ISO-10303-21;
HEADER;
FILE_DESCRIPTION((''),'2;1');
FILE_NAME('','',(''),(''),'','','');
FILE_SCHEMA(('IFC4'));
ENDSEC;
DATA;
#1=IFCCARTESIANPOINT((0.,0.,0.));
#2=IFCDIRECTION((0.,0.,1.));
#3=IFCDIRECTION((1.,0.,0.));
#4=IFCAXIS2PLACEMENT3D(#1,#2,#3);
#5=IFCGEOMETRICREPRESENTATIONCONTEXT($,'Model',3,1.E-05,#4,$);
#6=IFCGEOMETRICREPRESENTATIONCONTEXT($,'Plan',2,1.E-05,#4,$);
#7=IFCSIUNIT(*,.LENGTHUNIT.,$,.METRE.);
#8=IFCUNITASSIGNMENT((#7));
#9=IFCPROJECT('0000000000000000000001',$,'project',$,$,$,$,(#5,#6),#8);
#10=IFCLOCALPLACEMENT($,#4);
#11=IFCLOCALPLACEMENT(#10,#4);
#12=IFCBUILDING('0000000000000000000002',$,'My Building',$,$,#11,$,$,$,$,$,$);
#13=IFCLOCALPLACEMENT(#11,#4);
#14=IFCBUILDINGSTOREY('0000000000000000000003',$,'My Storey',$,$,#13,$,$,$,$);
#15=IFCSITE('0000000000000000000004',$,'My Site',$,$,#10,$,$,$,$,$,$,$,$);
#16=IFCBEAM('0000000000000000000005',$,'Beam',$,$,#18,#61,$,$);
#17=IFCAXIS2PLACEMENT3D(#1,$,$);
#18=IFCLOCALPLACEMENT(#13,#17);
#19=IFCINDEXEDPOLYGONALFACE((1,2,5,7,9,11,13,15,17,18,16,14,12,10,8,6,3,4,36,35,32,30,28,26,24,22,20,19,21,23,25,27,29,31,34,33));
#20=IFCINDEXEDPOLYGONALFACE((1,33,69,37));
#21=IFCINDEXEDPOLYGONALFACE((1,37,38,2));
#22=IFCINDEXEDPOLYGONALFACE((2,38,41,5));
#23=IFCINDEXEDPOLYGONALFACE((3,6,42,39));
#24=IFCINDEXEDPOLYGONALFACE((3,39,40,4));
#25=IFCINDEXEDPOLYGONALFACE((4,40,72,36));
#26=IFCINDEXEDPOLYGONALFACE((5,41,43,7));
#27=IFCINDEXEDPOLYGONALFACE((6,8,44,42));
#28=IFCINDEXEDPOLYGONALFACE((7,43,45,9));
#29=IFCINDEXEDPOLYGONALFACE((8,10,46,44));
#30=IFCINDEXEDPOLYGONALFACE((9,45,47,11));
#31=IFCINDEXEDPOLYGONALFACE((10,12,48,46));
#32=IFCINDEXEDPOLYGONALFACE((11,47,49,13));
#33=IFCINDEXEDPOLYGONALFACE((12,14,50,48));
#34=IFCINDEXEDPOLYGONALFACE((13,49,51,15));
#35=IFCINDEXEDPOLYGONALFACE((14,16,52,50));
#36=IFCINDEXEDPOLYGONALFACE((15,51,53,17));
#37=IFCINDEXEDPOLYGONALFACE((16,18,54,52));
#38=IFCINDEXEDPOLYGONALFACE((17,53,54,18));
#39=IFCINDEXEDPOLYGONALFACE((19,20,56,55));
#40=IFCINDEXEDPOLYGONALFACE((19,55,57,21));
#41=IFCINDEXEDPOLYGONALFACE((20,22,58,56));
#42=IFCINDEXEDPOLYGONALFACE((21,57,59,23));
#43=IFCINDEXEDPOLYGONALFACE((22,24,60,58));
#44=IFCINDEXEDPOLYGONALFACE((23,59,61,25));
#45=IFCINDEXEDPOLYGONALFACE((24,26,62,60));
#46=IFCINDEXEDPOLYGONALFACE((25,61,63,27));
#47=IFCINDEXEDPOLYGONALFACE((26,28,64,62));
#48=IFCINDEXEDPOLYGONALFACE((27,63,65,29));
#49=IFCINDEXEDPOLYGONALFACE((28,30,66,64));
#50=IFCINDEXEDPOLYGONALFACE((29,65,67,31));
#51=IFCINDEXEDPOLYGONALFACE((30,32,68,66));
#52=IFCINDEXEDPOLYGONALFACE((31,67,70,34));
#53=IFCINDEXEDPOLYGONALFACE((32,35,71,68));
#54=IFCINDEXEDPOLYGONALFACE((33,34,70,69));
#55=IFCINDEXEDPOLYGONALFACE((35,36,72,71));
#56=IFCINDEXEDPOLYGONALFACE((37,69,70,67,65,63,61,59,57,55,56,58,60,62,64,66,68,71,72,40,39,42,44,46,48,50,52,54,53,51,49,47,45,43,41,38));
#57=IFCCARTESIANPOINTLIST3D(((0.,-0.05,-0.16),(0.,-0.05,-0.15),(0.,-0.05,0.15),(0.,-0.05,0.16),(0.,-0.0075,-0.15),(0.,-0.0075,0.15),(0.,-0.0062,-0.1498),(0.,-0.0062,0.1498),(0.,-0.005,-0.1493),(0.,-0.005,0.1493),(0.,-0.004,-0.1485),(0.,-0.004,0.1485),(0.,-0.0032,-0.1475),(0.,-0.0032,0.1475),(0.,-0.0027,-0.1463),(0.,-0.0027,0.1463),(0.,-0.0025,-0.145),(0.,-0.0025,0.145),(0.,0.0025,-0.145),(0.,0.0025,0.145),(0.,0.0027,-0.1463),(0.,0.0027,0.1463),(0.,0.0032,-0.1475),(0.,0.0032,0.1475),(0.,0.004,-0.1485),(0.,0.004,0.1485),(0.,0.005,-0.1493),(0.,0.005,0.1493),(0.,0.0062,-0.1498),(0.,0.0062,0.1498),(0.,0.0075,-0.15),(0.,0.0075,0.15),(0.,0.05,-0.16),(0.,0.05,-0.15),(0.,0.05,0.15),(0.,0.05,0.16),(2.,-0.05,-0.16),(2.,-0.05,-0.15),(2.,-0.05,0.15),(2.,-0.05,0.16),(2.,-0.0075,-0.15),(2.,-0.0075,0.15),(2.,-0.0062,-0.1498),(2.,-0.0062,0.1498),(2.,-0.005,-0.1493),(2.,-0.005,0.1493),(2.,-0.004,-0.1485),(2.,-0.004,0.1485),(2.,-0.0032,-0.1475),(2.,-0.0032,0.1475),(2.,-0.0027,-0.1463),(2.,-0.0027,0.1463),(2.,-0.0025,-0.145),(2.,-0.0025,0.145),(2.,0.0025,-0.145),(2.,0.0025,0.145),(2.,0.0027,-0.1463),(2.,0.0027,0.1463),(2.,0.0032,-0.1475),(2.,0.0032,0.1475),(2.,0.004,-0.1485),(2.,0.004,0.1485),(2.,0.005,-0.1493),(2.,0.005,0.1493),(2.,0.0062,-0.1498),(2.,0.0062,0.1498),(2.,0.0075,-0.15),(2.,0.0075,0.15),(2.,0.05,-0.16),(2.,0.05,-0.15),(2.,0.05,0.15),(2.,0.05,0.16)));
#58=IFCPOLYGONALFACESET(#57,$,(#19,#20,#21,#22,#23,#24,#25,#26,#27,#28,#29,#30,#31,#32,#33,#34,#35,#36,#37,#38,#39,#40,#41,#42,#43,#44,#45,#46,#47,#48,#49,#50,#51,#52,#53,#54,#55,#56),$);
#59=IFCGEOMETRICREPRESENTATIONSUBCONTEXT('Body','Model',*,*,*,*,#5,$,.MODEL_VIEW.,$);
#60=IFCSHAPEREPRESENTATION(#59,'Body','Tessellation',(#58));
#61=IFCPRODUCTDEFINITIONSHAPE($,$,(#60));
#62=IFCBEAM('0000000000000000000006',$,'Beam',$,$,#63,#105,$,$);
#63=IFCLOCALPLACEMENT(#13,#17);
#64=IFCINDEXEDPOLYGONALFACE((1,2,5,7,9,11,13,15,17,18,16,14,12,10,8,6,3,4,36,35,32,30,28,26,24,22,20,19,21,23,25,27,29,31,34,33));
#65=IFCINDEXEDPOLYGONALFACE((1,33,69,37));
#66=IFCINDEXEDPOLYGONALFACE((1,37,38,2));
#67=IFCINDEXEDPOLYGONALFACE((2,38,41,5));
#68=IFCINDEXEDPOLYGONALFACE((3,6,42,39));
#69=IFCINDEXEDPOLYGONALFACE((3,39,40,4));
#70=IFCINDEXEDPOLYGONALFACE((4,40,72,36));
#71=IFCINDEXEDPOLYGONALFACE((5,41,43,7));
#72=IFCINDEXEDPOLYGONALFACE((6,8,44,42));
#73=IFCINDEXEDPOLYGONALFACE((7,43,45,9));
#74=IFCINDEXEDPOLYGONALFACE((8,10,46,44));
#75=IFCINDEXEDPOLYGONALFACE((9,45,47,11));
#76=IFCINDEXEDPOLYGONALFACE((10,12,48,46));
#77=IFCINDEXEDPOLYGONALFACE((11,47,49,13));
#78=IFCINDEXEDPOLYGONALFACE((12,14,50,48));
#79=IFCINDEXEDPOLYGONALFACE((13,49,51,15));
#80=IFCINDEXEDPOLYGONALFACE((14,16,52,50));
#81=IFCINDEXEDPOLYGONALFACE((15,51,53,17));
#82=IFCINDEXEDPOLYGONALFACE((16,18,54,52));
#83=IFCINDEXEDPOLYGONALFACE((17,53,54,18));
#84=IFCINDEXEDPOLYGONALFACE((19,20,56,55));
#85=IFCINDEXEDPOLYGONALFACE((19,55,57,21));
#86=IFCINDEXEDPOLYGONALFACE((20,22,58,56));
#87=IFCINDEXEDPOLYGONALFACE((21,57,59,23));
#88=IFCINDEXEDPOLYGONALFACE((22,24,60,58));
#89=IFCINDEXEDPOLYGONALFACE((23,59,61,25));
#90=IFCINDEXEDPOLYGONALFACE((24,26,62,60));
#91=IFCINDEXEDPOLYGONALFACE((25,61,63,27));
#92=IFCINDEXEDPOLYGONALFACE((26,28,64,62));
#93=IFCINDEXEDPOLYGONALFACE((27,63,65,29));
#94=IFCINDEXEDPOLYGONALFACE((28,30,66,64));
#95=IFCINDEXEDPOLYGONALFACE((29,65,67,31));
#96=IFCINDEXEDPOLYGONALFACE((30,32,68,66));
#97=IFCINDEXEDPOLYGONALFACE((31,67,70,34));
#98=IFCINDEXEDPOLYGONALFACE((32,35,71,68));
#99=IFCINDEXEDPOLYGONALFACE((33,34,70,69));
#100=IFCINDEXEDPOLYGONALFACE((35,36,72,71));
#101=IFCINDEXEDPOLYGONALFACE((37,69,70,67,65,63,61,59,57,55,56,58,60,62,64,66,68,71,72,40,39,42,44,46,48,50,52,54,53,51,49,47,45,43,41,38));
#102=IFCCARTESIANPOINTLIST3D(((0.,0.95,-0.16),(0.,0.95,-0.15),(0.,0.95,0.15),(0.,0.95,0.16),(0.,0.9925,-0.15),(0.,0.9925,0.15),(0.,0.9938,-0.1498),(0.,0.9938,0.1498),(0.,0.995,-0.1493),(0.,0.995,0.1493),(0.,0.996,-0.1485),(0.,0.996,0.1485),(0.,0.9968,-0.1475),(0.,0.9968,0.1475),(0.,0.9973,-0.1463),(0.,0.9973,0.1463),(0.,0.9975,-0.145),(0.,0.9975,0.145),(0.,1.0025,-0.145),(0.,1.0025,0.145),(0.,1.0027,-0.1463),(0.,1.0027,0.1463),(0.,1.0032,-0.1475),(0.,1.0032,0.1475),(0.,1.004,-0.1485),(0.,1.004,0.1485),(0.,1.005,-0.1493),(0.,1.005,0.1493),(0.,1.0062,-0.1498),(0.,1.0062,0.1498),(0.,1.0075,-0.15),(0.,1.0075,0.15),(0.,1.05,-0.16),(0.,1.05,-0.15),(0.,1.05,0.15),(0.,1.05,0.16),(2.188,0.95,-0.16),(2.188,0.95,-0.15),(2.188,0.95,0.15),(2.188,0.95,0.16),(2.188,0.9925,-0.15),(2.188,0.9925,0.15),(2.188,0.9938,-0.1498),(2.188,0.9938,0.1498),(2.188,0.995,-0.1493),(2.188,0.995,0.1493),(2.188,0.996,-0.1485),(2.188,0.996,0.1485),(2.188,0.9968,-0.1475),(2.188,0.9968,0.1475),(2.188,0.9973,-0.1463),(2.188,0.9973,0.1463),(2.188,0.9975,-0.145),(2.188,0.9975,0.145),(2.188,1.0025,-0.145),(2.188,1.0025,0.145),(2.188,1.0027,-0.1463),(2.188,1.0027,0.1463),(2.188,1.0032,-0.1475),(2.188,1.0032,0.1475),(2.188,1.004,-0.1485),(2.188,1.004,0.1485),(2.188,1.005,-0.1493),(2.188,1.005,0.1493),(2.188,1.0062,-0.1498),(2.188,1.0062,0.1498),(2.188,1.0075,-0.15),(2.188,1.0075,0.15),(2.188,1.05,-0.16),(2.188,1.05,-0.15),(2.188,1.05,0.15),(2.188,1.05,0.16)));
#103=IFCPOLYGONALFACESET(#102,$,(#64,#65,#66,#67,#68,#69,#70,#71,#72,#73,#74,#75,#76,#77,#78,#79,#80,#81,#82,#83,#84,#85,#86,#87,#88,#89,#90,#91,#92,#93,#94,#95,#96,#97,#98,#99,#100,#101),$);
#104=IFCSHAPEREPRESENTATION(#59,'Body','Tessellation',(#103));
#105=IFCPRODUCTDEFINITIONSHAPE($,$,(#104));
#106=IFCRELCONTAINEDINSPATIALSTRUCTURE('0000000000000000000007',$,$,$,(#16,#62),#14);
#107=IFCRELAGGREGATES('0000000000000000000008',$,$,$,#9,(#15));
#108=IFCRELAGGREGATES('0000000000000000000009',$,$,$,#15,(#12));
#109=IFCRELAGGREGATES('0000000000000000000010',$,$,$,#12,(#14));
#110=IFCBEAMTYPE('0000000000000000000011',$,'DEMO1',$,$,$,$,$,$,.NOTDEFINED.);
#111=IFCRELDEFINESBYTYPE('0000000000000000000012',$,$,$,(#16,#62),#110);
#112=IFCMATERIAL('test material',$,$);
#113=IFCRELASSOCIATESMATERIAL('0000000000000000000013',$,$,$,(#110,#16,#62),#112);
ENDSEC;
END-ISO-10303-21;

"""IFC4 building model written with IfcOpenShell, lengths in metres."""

from ifc_helpers import new_model, si_unit, frame, origin_with_axes, place, context, subcontext, project, spatial, i_section, extrude, material, material_profile, profile_set, profile_usage, type_object, element, save


model = new_model("IFC4")

# Units and contexts
model_context = context("Model", 3, precision=1e-05, world=origin_with_axes())
plan_context = context("Plan", 2, precision=1e-05, world=origin_with_axes())
body_context = subcontext(model_context, "Body", "Model", "MODEL_VIEW")
ifc_project = project(units=[si_unit("LENGTHUNIT", "METRE")], contexts=[model_context, plan_context])

# Site, building, storey
site_placement = place(None, origin_with_axes())
site = spatial("IfcSite", under=ifc_project, at=site_placement, Name="My Site")
building_placement = place(site_placement, origin_with_axes())
building = spatial("IfcBuilding", under=site, at=building_placement, Name="My Building")
storey_placement = place(building_placement, origin_with_axes())
storey = spatial("IfcBuildingStorey", under=building, at=storey_placement, Name="My Storey")

# Beams
ifc_material = material(Name="test material")
ifc_material_profile = material_profile(ifc_material, i_section(OverallWidth=0.1, OverallDepth=0.32, WebThickness=0.005, FlangeThickness=0.01, FilletRadius=0.005))
ifc_profile_set = profile_set([ifc_material_profile])
ifc_profile_usage = profile_usage(ifc_profile_set)
beam_type = type_object("IfcBeamType", Name="DEMO1", material=ifc_profile_set)
beam_1_placement = place(storey_placement, frame((0.0, 0.0, 0.0), z_axis=(1.0, 0.0, 0.0), x_axis=(0.0, 1.0, 0.0)))
element("IfcBeam", 1, at=beam_1_placement, inside=storey, type_object=beam_type, material=ifc_profile_usage, Name="Beam", context=body_context, shape_type="SweptSolid", body=[
    extrude(i_section(OverallWidth=0.1, OverallDepth=0.32, WebThickness=0.005, FlangeThickness=0.01, FilletRadius=0.005), None, (0.0, 0.0, 1.0), 2.0),
])
beam_2_placement = place(storey_placement, frame((0.0, 1.0, 0.0), z_axis=(1.0, 0.0, 0.0), x_axis=(0.0, 1.0, 0.0)))
element("IfcBeam", 2, at=beam_2_placement, inside=storey, type_object=beam_type, material=ifc_profile_usage, Name="Beam", context=body_context, shape_type="SweptSolid", body=[
    extrude(i_section(OverallWidth=0.1, OverallDepth=0.32, WebThickness=0.005, FlangeThickness=0.01, FilletRadius=0.005), None, (0.0, 0.0, 1.0), 2.188),
])

save(model, "model.ifc")
